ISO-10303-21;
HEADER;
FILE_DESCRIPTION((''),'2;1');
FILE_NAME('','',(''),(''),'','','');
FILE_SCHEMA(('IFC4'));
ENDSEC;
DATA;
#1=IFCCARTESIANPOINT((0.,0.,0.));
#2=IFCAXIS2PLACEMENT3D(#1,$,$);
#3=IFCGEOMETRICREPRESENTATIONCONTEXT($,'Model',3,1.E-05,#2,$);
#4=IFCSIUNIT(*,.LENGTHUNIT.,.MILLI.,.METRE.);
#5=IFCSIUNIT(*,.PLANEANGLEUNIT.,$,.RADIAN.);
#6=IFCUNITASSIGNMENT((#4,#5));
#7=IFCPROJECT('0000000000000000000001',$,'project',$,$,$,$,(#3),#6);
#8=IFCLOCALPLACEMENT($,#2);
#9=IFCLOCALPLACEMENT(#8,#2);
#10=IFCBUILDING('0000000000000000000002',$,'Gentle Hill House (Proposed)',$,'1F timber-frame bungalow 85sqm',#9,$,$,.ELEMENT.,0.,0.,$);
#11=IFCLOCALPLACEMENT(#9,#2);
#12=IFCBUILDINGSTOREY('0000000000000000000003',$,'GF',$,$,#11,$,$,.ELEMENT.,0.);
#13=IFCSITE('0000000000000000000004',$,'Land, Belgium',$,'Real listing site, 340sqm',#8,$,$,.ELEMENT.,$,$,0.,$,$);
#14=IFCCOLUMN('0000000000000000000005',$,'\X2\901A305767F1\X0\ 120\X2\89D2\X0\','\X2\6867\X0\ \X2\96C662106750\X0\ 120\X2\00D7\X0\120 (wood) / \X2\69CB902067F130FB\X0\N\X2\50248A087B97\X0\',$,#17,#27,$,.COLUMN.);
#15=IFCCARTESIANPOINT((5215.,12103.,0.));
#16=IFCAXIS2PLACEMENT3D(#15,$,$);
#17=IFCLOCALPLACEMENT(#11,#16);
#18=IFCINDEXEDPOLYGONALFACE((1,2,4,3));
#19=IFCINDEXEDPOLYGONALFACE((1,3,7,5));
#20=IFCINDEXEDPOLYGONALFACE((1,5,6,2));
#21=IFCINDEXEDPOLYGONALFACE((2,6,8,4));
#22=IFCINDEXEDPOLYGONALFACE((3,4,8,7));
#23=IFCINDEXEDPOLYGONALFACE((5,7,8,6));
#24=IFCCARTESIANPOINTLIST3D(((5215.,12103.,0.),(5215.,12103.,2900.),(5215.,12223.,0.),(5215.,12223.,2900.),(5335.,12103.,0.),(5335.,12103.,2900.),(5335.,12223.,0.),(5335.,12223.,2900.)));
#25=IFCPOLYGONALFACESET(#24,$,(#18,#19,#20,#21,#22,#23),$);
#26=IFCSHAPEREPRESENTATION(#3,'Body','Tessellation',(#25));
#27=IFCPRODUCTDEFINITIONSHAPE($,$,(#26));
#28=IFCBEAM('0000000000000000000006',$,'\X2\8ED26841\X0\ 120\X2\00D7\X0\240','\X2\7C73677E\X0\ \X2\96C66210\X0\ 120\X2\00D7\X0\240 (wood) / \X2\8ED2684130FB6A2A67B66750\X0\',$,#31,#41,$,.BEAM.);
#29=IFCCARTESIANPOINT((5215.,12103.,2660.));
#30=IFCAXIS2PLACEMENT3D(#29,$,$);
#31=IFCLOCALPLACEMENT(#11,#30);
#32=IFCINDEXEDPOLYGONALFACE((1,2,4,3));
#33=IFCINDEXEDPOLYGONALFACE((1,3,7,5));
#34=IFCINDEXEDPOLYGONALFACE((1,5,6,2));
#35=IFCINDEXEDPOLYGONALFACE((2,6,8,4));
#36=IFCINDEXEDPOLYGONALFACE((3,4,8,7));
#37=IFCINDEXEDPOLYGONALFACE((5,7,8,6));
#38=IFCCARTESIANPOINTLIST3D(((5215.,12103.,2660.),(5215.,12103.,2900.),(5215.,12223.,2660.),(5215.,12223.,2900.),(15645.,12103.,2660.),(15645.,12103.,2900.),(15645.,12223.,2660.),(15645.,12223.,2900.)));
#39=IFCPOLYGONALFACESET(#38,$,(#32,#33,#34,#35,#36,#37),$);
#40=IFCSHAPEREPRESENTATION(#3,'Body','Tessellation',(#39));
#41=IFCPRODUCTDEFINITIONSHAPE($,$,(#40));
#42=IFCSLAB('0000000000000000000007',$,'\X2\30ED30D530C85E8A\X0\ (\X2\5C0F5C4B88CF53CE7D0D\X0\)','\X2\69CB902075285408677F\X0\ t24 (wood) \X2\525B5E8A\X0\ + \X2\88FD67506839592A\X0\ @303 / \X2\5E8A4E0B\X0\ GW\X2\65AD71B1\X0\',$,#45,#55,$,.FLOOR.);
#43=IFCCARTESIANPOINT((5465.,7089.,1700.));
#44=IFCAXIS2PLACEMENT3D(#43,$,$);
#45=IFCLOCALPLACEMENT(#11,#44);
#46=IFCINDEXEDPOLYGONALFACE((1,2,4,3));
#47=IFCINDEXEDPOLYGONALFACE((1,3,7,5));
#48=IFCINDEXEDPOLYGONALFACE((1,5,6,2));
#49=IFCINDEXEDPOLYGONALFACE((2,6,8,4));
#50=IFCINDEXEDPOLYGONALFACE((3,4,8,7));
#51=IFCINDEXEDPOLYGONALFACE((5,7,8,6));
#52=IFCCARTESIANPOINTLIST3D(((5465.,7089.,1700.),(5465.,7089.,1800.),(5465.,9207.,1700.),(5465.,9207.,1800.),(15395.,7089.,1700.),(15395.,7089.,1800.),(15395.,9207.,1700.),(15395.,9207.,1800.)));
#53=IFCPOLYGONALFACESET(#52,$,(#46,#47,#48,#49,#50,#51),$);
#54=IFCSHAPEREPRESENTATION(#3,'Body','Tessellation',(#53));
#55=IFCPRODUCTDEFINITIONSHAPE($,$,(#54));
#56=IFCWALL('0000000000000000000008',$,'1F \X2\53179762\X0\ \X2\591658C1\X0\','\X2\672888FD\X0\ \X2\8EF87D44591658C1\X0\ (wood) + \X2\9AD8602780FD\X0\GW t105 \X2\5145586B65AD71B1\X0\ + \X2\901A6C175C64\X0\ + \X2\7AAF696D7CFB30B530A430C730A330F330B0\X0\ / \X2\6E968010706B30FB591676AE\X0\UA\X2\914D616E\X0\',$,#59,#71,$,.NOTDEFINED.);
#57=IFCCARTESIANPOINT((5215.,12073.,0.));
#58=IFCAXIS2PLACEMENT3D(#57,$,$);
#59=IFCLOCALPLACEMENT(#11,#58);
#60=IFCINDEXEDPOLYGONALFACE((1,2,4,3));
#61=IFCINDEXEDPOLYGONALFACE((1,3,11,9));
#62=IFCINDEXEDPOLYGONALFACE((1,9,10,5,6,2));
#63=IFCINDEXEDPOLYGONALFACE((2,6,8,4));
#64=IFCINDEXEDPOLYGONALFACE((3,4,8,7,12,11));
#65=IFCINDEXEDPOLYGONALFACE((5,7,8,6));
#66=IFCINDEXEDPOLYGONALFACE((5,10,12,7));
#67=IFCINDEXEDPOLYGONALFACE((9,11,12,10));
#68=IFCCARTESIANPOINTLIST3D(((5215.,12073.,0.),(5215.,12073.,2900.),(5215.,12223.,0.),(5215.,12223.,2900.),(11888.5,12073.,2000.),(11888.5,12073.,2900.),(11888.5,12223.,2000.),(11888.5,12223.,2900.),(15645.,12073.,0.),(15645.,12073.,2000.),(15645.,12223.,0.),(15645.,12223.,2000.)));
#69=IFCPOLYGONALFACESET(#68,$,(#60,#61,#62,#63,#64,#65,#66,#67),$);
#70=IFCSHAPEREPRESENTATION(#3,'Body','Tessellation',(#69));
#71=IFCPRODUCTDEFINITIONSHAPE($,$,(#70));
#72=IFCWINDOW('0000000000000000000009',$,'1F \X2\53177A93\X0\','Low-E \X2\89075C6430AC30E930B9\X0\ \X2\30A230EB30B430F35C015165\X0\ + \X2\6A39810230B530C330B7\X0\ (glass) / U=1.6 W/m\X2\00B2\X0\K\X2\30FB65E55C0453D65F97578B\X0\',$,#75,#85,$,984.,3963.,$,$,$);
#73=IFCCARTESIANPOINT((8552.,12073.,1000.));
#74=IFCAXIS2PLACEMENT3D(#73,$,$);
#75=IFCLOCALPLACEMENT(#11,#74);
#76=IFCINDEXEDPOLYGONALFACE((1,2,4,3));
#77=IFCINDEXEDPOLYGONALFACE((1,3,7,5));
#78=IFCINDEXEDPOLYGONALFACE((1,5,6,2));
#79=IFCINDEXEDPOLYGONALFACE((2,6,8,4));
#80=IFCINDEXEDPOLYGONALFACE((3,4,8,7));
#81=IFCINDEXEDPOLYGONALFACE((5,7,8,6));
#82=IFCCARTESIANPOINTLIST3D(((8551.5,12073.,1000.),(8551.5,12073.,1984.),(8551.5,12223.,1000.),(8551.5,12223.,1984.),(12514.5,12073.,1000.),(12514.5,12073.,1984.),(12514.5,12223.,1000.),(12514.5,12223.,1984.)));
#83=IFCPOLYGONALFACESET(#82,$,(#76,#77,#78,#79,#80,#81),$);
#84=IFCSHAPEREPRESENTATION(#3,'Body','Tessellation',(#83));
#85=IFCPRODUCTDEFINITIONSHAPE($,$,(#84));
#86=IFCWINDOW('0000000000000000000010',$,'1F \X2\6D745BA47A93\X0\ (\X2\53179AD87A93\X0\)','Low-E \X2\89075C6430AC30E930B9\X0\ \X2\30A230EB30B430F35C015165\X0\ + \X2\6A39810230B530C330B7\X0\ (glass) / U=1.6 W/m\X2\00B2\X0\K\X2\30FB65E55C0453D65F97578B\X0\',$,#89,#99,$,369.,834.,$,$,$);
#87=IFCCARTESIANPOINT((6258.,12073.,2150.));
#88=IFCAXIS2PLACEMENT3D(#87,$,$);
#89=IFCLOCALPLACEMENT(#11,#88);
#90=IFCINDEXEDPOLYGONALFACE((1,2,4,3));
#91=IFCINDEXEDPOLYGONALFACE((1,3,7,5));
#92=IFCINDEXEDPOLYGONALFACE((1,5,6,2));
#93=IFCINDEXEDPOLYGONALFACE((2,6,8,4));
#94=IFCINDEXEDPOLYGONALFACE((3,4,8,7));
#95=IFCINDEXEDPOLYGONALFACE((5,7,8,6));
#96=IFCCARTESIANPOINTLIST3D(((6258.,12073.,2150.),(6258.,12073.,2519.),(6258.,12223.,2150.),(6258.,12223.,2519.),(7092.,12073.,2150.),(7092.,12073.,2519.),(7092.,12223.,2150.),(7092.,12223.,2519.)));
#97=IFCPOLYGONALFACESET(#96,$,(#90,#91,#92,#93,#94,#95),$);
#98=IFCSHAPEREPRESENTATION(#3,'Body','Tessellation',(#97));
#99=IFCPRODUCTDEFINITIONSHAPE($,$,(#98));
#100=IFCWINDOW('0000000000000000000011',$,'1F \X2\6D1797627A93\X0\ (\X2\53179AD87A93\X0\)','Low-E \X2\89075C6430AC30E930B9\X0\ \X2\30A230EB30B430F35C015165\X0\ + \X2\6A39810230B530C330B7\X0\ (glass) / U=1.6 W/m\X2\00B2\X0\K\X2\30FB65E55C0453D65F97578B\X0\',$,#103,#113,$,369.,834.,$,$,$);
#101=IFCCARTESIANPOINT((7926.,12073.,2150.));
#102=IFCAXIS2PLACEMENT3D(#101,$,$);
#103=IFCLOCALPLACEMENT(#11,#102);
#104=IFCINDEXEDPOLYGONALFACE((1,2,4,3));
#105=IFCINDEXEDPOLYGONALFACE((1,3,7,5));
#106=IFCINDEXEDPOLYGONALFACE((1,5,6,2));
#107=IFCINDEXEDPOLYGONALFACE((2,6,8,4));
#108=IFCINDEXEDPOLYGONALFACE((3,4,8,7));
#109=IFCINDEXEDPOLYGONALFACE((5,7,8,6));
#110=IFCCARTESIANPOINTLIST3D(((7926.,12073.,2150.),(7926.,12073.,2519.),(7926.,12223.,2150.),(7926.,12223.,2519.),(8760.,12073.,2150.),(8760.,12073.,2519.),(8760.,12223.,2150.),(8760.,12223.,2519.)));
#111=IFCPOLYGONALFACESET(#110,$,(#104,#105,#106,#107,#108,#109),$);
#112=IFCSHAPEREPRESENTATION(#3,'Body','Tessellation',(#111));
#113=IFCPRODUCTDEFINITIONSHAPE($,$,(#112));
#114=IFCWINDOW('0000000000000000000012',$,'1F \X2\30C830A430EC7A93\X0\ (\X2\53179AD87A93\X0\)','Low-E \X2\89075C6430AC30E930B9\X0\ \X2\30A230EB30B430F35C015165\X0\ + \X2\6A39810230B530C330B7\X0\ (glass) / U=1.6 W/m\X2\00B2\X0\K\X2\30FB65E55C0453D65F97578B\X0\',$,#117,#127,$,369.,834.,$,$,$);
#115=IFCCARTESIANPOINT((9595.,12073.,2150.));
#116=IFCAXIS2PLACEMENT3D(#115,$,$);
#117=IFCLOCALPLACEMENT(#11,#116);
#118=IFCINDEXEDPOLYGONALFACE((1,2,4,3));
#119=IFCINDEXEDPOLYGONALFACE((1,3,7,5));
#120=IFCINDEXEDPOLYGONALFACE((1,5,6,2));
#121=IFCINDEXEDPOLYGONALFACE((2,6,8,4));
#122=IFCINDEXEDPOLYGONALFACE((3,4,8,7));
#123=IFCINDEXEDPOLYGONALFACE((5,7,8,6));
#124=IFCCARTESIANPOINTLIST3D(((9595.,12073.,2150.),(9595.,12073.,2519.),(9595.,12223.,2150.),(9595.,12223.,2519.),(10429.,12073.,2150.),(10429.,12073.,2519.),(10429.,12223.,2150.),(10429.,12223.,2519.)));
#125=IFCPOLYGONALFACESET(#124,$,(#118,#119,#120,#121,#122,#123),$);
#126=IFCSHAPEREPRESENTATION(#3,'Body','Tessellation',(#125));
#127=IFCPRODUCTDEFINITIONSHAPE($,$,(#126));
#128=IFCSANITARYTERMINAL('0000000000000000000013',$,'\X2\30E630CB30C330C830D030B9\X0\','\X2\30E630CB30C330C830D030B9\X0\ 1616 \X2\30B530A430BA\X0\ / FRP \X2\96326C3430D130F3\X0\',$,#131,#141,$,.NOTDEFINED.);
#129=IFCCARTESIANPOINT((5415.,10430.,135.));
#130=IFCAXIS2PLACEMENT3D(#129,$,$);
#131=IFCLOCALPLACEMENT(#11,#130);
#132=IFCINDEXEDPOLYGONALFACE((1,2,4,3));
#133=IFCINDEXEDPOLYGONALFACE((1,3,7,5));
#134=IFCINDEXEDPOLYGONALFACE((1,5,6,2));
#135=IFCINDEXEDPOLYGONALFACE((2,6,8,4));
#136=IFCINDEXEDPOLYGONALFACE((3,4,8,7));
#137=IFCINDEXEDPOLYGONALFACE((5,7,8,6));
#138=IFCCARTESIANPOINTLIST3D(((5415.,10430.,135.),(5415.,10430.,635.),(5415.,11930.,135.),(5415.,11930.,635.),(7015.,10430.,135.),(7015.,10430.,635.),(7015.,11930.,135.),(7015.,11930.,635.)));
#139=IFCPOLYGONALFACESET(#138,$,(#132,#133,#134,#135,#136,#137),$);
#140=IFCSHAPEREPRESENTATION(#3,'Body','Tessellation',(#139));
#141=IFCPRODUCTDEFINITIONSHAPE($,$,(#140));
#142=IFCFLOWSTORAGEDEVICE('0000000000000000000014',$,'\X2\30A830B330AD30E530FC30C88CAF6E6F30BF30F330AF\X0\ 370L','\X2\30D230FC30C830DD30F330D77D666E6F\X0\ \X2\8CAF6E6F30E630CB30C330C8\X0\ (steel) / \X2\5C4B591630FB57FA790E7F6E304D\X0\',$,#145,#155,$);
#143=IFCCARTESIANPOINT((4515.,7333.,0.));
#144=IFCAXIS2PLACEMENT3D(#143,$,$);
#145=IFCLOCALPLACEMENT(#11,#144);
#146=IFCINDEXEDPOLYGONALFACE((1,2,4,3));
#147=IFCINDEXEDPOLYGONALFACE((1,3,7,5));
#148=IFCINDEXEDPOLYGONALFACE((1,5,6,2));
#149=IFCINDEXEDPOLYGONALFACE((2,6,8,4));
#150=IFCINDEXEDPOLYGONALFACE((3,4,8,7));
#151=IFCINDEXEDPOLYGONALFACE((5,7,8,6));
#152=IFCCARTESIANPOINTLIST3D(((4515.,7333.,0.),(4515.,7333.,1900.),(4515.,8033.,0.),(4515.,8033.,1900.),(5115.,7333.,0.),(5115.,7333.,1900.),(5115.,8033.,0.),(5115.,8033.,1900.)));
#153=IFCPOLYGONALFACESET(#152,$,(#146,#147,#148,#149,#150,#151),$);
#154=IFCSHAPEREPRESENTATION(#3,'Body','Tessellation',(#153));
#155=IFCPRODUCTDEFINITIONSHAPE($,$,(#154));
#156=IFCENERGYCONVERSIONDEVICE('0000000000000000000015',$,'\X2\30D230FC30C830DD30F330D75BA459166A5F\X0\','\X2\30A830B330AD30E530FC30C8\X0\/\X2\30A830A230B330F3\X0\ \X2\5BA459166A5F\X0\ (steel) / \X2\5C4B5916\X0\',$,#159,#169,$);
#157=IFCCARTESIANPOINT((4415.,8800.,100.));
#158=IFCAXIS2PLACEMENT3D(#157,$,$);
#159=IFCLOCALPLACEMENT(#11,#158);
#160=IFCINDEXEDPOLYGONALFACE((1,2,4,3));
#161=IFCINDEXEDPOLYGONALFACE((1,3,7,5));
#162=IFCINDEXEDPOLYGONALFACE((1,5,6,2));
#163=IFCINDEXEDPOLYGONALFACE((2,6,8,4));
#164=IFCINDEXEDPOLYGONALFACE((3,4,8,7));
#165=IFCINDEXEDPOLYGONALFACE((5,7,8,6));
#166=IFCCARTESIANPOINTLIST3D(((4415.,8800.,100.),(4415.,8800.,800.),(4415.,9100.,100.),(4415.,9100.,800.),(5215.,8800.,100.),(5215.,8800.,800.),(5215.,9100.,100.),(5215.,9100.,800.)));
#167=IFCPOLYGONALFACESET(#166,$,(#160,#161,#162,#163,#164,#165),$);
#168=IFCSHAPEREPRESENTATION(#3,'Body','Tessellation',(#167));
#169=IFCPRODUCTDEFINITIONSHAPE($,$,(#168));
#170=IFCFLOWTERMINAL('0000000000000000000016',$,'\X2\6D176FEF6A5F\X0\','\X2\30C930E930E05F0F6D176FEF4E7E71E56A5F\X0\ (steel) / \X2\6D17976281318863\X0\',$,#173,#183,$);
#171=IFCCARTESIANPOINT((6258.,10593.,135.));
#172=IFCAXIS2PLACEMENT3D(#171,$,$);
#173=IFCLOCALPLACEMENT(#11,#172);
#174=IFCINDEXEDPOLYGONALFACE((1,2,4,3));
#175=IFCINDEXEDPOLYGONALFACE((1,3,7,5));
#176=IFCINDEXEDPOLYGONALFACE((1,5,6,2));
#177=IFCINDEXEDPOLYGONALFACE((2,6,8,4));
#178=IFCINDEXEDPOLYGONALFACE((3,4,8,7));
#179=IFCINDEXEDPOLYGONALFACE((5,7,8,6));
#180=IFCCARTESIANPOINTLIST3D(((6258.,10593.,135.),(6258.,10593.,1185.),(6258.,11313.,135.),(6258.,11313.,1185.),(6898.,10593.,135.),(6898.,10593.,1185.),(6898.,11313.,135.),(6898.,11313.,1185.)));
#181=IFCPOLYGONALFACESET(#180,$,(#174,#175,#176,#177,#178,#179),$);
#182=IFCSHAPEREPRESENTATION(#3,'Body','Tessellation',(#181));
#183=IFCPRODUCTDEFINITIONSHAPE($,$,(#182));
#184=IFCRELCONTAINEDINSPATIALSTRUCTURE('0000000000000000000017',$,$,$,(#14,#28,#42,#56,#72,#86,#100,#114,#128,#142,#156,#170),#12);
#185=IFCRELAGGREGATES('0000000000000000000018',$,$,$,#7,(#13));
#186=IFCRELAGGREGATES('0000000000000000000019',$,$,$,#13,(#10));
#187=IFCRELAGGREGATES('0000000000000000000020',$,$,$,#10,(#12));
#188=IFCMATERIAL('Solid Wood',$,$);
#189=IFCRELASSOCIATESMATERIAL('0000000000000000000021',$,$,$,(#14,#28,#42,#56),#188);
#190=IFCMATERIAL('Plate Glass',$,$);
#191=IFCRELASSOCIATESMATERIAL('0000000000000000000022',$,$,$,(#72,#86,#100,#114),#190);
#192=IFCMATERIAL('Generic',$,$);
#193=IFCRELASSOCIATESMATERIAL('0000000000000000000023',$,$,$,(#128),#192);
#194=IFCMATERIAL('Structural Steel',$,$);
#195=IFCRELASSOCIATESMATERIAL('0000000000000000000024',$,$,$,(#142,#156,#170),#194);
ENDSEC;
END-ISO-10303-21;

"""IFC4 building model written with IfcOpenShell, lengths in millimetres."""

from ifc_helpers import new_model, si_unit, frame, frame_2d, origin, place, context, project, spatial, rectangle, extrude, material, element, fill, save


model = new_model("IFC4")

# Units and contexts
model_context = context("Model", 3, precision=1e-05, world=origin())
ifc_project = project(units=[si_unit("LENGTHUNIT", "METRE", prefix="MILLI"), si_unit("PLANEANGLEUNIT", "RADIAN")], contexts=[model_context])

# Site, building, storey
site_placement = place(None, origin())
site = spatial("IfcSite", under=ifc_project, at=site_placement, Name="Land, Belgium", ObjectType="Real listing site, 340sqm", CompositionType="ELEMENT", RefElevation=0.0)
building_placement = place(site_placement, origin())
building = spatial("IfcBuilding", under=site, at=building_placement, Name="Gentle Hill House (Proposed)", ObjectType="1F timber-frame bungalow 85sqm", CompositionType="ELEMENT", ElevationOfRefHeight=0.0, ElevationOfTerrain=0.0)
storey_placement = place(building_placement, origin())
storey = spatial("IfcBuildingStorey", under=building, at=storey_placement, Name="GF", CompositionType="ELEMENT", Elevation=0.0)

# Column
ifc_material_1 = material(Name="Solid Wood")
column_1_placement = place(storey_placement, frame((5215.0, 12103.0, 0.0)))
element("IfcColumn", 1, at=column_1_placement, inside=storey, material=ifc_material_1, Name="通し柱 120角", Description="桧 集成材 120×120 (wood) / 構造柱・N値計算", PredefinedType="COLUMN", context=model_context, shape_type="SweptSolid", body=[
    extrude(rectangle(XDim=120.0, YDim=120.0, at=frame_2d((60.0, 60.0))), frame((5215.0, 12103.0, 0.0)), (0.0, 0.0, 1.0), 2900.0),
])

# Beam
beam_1_placement = place(storey_placement, frame((5215.0, 12103.0, 2660.0)))
element("IfcBeam", 2, at=beam_1_placement, inside=storey, material=ifc_material_1, Name="軒桁 120×240", Description="米松 集成 120×240 (wood) / 軒桁・横架材", PredefinedType="BEAM", context=model_context, shape_type="SweptSolid", body=[
    extrude(rectangle(XDim=10430.0, YDim=120.0, at=frame_2d((5215.0, 60.0))), frame((5215.0, 12103.0, 2660.0)), (0.0, 0.0, 1.0), 240.0),
])

# Slab
slab_placement = place(storey_placement, frame((5465.0, 7089.0, 1700.0)))
element("IfcSlab", 3, at=slab_placement, inside=storey, material=ifc_material_1, Name="ロフト床 (小屋裏収納)", Description="構造用合板 t24 (wood) 剛床 + 製材根太 @303 / 床下 GW断熱", PredefinedType="FLOOR", context=model_context, shape_type="SweptSolid", body=[
    extrude(rectangle(XDim=9930.0, YDim=2118.0, at=frame_2d((4965.0, 1059.0))), frame((5465.0, 7089.0, 1700.0)), (0.0, 0.0, 1.0), 100.0),
])

# Wall, openings, windows
wall_1_placement = place(storey_placement, frame((5215.0, 12073.0, 0.0)))
wall_1 = element("IfcWall", 4, at=wall_1_placement, inside=storey, material=ifc_material_1, Name="1F 北面 外壁", Description="木製 軸組外壁 (wood) + 高性能GW t105 充填断熱 + 通気層 + 窯業系サイディング / 準耐火・外皮UA配慮", PredefinedType="NOTDEFINED", context=model_context, shape_type="SweptSolid", body=[
    extrude(rectangle(XDim=10430.0, YDim=150.0, at=frame_2d((5215.0, 75.0))), frame((5215.0, 12073.0, 0.0)), (0.0, 0.0, 1.0), 2900.0),
])
opening_1_placement = place(storey_placement, frame((8552.0, 12073.0, 1000.0)))
opening_1 = element("IfcOpeningElement", 5, at=opening_1_placement, cuts=wall_1, PredefinedType="NOTDEFINED", context=model_context, shape_type="SweptSolid", body=[
    extrude(rectangle(XDim=3963.0, YDim=150.0, at=frame_2d((1981.0, 75.0))), frame((8552.0, 12073.0, 1000.0)), (0.0, 0.0, 1.0), 984.0),
])
opening_2_placement = place(storey_placement, frame((6258.0, 12073.0, 2150.0)))
opening_2 = element("IfcOpeningElement", 6, at=opening_2_placement, cuts=wall_1, PredefinedType="NOTDEFINED", context=model_context, shape_type="SweptSolid", body=[
    extrude(rectangle(XDim=834.0, YDim=150.0, at=frame_2d((417.0, 75.0))), frame((6258.0, 12073.0, 2150.0)), (0.0, 0.0, 1.0), 369.0),
])
opening_3_placement = place(storey_placement, frame((7926.0, 12073.0, 2150.0)))
opening_3 = element("IfcOpeningElement", 7, at=opening_3_placement, cuts=wall_1, PredefinedType="NOTDEFINED", context=model_context, shape_type="SweptSolid", body=[
    extrude(rectangle(XDim=834.0, YDim=150.0, at=frame_2d((417.0, 75.0))), frame((7926.0, 12073.0, 2150.0)), (0.0, 0.0, 1.0), 369.0),
])
opening_4_placement = place(storey_placement, frame((9595.0, 12073.0, 2150.0)))
opening_4 = element("IfcOpeningElement", 8, at=opening_4_placement, cuts=wall_1, PredefinedType="NOTDEFINED", context=model_context, shape_type="SweptSolid", body=[
    extrude(rectangle(XDim=834.0, YDim=150.0, at=frame_2d((417.0, 75.0))), frame((9595.0, 12073.0, 2150.0)), (0.0, 0.0, 1.0), 369.0),
])
ifc_material_2 = material(Name="Plate Glass")
window_1_placement = place(storey_placement, frame((8552.0, 12073.0, 1000.0)))
window_1 = element("IfcWindow", 9, at=window_1_placement, inside=storey, material=ifc_material_2, Name="1F 北窓", Description="Low-E 複層ガラス アルゴン封入 + 樹脂サッシ (glass) / U=1.6 W/m²K・日射取得型", OverallHeight=984.0, OverallWidth=3963.0, context=model_context, shape_type="SweptSolid", body=[
    extrude(rectangle(XDim=3963.0, YDim=150.0, at=frame_2d((1981.0, 75.0))), frame((8552.0, 12073.0, 1000.0)), (0.0, 0.0, 1.0), 984.0),
])
fill(opening_1, window_1)
window_2_placement = place(storey_placement, frame((6258.0, 12073.0, 2150.0)))
window_2 = element("IfcWindow", 10, at=window_2_placement, inside=storey, material=ifc_material_2, Name="1F 浴室窓 (北高窓)", Description="Low-E 複層ガラス アルゴン封入 + 樹脂サッシ (glass) / U=1.6 W/m²K・日射取得型", OverallHeight=369.0, OverallWidth=834.0, context=model_context, shape_type="SweptSolid", body=[
    extrude(rectangle(XDim=834.0, YDim=150.0, at=frame_2d((417.0, 75.0))), frame((6258.0, 12073.0, 2150.0)), (0.0, 0.0, 1.0), 369.0),
])
fill(opening_2, window_2)
window_3_placement = place(storey_placement, frame((7926.0, 12073.0, 2150.0)))
window_3 = element("IfcWindow", 11, at=window_3_placement, inside=storey, material=ifc_material_2, Name="1F 洗面窓 (北高窓)", Description="Low-E 複層ガラス アルゴン封入 + 樹脂サッシ (glass) / U=1.6 W/m²K・日射取得型", OverallHeight=369.0, OverallWidth=834.0, context=model_context, shape_type="SweptSolid", body=[
    extrude(rectangle(XDim=834.0, YDim=150.0, at=frame_2d((417.0, 75.0))), frame((7926.0, 12073.0, 2150.0)), (0.0, 0.0, 1.0), 369.0),
])
fill(opening_3, window_3)
window_4_placement = place(storey_placement, frame((9595.0, 12073.0, 2150.0)))
window_4 = element("IfcWindow", 12, at=window_4_placement, inside=storey, material=ifc_material_2, Name="1F トイレ窓 (北高窓)", Description="Low-E 複層ガラス アルゴン封入 + 樹脂サッシ (glass) / U=1.6 W/m²K・日射取得型", OverallHeight=369.0, OverallWidth=834.0, context=model_context, shape_type="SweptSolid", body=[
    extrude(rectangle(XDim=834.0, YDim=150.0, at=frame_2d((417.0, 75.0))), frame((9595.0, 12073.0, 2150.0)), (0.0, 0.0, 1.0), 369.0),
])
fill(opening_4, window_4)

# Sanitary terminal
ifc_material_3 = material(Name="Generic")
sanitary_terminal_placement = place(storey_placement, frame((5415.0, 10430.0, 135.0)))
element("IfcSanitaryTerminal", 13, at=sanitary_terminal_placement, inside=storey, material=ifc_material_3, Name="ユニットバス", Description="ユニットバス 1616 サイズ / FRP 防水パン", PredefinedType="NOTDEFINED", context=model_context, shape_type="SweptSolid", body=[
    extrude(rectangle(XDim=1600.0, YDim=1500.0, at=frame_2d((800.0, 750.0))), frame((5415.0, 10430.0, 135.0)), (0.0, 0.0, 1.0), 500.0),
])

# Flow storage device
ifc_material_4 = material(Name="Structural Steel")
flow_storage_device_placement = place(storey_placement, frame((4515.0, 7333.0, 0.0)))
element("IfcFlowStorageDevice", 14, at=flow_storage_device_placement, inside=storey, material=ifc_material_4, Name="エコキュート貯湯タンク 370L", Description="ヒートポンプ給湯 貯湯ユニット (steel) / 屋外・基礎置き", context=model_context, shape_type="SweptSolid", body=[
    extrude(rectangle(XDim=600.0, YDim=700.0, at=frame_2d((300.0, 350.0))), frame((4515.0, 7333.0, 0.0)), (0.0, 0.0, 1.0), 1900.0),
])

# Energy conversion device
energy_conversion_device_placement = place(storey_placement, frame((4415.0, 8800.0, 100.0)))
element("IfcEnergyConversionDevice", 15, at=energy_conversion_device_placement, inside=storey, material=ifc_material_4, Name="ヒートポンプ室外機", Description="エコキュート/エアコン 室外機 (steel) / 屋外", context=model_context, shape_type="SweptSolid", body=[
    extrude(rectangle(XDim=800.0, YDim=300.0, at=frame_2d((400.0, 150.0))), frame((4415.0, 8800.0, 100.0)), (0.0, 0.0, 1.0), 700.0),
])

# Flow terminal
flow_terminal_placement = place(storey_placement, frame((6258.0, 10593.0, 135.0)))
element("IfcFlowTerminal", 16, at=flow_terminal_placement, inside=storey, material=ifc_material_4, Name="洗濯機", Description="ドラム式洗濯乾燥機 (steel) / 洗面脱衣", context=model_context, shape_type="SweptSolid", body=[
    extrude(rectangle(XDim=640.0, YDim=720.0, at=frame_2d((320.0, 360.0))), frame((6258.0, 10593.0, 135.0)), (0.0, 0.0, 1.0), 1050.0),
])

save(model, "model.ifc")
